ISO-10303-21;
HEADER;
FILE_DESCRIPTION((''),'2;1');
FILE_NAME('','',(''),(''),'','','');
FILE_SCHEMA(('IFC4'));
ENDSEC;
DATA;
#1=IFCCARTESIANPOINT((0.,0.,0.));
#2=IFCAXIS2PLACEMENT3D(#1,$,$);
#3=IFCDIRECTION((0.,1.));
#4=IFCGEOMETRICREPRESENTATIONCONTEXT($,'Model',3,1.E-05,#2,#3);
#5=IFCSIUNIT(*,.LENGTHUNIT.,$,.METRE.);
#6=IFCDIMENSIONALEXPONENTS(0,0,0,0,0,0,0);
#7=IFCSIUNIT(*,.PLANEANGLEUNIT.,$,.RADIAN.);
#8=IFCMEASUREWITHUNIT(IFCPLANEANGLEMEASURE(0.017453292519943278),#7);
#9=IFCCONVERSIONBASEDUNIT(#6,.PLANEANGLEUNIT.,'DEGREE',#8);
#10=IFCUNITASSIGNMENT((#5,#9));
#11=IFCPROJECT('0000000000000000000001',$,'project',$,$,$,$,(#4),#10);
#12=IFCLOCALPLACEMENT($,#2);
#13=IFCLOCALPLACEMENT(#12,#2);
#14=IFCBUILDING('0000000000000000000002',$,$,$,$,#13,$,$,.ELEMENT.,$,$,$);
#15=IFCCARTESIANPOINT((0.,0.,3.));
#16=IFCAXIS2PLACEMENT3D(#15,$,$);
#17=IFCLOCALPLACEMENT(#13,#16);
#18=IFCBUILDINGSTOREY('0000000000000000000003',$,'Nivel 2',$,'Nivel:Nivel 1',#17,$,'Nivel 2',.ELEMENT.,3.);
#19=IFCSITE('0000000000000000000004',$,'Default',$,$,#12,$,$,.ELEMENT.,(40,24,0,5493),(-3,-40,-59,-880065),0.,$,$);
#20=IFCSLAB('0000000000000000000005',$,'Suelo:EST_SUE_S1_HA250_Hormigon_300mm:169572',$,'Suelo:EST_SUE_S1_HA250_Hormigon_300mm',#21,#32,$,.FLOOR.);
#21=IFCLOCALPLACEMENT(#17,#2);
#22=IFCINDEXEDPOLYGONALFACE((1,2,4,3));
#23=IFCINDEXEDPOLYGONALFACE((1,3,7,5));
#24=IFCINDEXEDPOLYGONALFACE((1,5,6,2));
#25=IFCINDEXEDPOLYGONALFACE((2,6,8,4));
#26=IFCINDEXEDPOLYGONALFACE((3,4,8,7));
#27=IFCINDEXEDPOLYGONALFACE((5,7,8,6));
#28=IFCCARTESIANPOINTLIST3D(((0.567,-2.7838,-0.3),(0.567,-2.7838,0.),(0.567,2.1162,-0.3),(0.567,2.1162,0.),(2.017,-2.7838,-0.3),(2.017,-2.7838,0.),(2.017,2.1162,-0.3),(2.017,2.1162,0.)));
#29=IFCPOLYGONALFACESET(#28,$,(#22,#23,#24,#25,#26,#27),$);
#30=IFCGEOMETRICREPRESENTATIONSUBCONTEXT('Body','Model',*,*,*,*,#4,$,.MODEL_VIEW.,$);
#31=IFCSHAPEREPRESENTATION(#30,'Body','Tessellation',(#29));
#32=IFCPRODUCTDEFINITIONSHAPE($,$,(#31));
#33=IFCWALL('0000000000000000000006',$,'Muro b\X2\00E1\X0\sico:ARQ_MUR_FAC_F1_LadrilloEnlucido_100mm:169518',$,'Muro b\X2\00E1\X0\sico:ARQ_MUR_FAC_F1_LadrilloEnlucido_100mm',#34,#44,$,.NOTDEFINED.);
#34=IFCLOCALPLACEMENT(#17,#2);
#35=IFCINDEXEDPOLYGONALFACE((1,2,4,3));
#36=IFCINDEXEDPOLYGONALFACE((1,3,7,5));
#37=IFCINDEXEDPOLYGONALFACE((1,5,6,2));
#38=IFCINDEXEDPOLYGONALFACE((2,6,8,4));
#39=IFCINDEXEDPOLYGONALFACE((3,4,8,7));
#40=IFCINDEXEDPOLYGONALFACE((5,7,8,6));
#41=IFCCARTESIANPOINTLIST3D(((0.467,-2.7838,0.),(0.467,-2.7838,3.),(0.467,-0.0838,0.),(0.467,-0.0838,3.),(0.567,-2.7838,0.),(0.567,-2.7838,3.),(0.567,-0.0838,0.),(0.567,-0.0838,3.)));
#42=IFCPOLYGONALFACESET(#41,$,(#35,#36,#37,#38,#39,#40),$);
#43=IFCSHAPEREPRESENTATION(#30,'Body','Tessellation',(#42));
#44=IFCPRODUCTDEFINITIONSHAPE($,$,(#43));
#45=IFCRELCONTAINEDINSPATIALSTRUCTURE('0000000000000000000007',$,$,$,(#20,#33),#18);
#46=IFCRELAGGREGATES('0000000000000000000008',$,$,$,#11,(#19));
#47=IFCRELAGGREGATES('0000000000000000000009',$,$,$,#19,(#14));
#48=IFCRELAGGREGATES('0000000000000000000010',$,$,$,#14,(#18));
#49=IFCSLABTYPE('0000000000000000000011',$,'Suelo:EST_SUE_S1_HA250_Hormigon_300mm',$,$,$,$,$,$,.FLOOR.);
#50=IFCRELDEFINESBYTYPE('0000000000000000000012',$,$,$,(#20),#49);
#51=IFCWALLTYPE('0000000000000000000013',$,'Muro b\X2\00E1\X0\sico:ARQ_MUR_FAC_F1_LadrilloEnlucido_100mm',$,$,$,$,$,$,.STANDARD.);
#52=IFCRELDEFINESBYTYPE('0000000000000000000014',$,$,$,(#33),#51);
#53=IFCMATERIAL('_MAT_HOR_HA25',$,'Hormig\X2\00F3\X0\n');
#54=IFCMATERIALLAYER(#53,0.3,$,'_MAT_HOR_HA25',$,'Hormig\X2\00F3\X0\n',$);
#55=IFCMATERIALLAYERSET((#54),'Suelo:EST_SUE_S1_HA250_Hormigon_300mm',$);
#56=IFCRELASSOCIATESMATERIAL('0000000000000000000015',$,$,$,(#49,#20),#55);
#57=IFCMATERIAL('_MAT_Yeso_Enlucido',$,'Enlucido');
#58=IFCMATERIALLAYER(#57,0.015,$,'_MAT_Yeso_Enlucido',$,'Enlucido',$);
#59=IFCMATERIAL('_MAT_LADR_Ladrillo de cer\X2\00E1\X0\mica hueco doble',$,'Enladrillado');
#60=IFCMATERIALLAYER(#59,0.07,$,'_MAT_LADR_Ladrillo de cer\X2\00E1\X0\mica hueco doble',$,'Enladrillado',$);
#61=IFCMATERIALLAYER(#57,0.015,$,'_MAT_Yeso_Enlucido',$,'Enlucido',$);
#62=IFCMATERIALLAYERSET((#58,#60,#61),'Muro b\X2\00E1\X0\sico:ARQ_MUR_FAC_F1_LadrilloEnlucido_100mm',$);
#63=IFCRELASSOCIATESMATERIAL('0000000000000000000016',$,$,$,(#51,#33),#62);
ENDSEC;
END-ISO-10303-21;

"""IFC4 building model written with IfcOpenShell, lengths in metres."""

from ifc_helpers import new_model, entity, si_unit, converted_unit, direction, frame, frame_2d, origin, place, context, subcontext, project, spatial, rectangle, extrude, material, layer, layer_set, layer_usage, type_object, element, save


model = new_model("IFC4")

# Units and contexts
model_context = context("Model", 3, precision=1e-05, world=origin(), true_north=direction((0.0, 1.0)))
body_context = subcontext(model_context, "Body", "Model", "MODEL_VIEW")
ifc_project = project(units=[si_unit("LENGTHUNIT", "METRE"), converted_unit("PLANEANGLEUNIT", "DEGREE", entity("IfcPlaneAngleMeasure", 0.017453292519943278), si_unit("PLANEANGLEUNIT", "RADIAN"), dimensions=[0, 0, 0, 0, 0, 0, 0])], contexts=[model_context])

# Site, building, storey
site_placement = place(None, origin())
site = spatial("IfcSite", under=ifc_project, at=site_placement, Name="Default", CompositionType="ELEMENT", RefLatitude=(40, 24, 0, 5493), RefLongitude=(-3, -40, -59, -880065), RefElevation=0.0)
building_placement = place(site_placement, origin())
building = spatial("IfcBuilding", under=site, at=building_placement, CompositionType="ELEMENT")
storey_placement = place(building_placement, frame((0.0, 0.0, 3.0)))
storey = spatial("IfcBuildingStorey", under=building, at=storey_placement, Name="Nivel 2", ObjectType="Nivel:Nivel 1", LongName="Nivel 2", CompositionType="ELEMENT", Elevation=3.0)

# Slab
ifc_material_1 = material(Name="_MAT_HOR_HA25", Category="Hormigón")
ifc_layer_1 = layer(ifc_material_1, 0.3, Name="_MAT_HOR_HA25", Category="Hormigón")
ifc_layer_set_1 = layer_set([ifc_layer_1], Name="Suelo:EST_SUE_S1_HA250_Hormigon_300mm")
ifc_layer_usage_1 = layer_usage(ifc_layer_set_1, "AXIS3", "POSITIVE", 0.0)
slab_type = type_object("IfcSlabType", Name="Suelo:EST_SUE_S1_HA250_Hormigon_300mm", PredefinedType="FLOOR", material=ifc_layer_set_1)
slab_placement = place(storey_placement, origin())
element("IfcSlab", 1, at=slab_placement, inside=storey, type_object=slab_type, material=ifc_layer_usage_1, Name="Suelo:EST_SUE_S1_HA250_Hormigon_300mm:169572", ObjectType="Suelo:EST_SUE_S1_HA250_Hormigon_300mm", PredefinedType="FLOOR", context=body_context, shape_type="SweptSolid", body=[
    extrude(rectangle(XDim=4.9, YDim=1.45, at=frame_2d((0.0, 0.0), x_axis=(1.0, 0.0))), frame((1.292, -0.3338, 0.0), z_axis=(0.0, 0.0, -1.0), x_axis=(0.0, 1.0, 0.0)), (0.0, 0.0, 1.0), 0.3),
])

# Wall
ifc_material_2 = material(Name="_MAT_Yeso_Enlucido", Category="Enlucido")
ifc_layer_2 = layer(ifc_material_2, 0.015, Name="_MAT_Yeso_Enlucido", Category="Enlucido")
ifc_material_3 = material(Name="_MAT_LADR_Ladrillo de cerámica hueco doble", Category="Enladrillado")
ifc_layer_3 = layer(ifc_material_3, 0.07, Name="_MAT_LADR_Ladrillo de cerámica hueco doble", Category="Enladrillado")
ifc_layer_4 = layer(ifc_material_2, 0.015, Name="_MAT_Yeso_Enlucido", Category="Enlucido")
ifc_layer_set_2 = layer_set([ifc_layer_2, ifc_layer_3, ifc_layer_4], Name="Muro básico:ARQ_MUR_FAC_F1_LadrilloEnlucido_100mm")
ifc_layer_usage_2 = layer_usage(ifc_layer_set_2, "AXIS2", "NEGATIVE", 0.05)
wall_type = type_object("IfcWallType", Name="Muro básico:ARQ_MUR_FAC_F1_LadrilloEnlucido_100mm", PredefinedType="STANDARD", material=ifc_layer_set_2)
wall_placement = place(storey_placement, frame((0.517, -2.7838, 0.0), z_axis=(0.0, 0.0, 1.0), x_axis=(0.0, 1.0, 0.0)))
element("IfcWall", 2, at=wall_placement, inside=storey, type_object=wall_type, material=ifc_layer_usage_2, Name="Muro básico:ARQ_MUR_FAC_F1_LadrilloEnlucido_100mm:169518", ObjectType="Muro básico:ARQ_MUR_FAC_F1_LadrilloEnlucido_100mm", PredefinedType="NOTDEFINED", context=body_context, shape_type="SweptSolid", body=[
    extrude(rectangle(XDim=2.7, YDim=0.1, at=frame_2d((1.35, 0.0), x_axis=(-1.0, 0.0))), origin(), (0.0, 0.0, 1.0), 3.0),
])

save(model, "model.ifc")
